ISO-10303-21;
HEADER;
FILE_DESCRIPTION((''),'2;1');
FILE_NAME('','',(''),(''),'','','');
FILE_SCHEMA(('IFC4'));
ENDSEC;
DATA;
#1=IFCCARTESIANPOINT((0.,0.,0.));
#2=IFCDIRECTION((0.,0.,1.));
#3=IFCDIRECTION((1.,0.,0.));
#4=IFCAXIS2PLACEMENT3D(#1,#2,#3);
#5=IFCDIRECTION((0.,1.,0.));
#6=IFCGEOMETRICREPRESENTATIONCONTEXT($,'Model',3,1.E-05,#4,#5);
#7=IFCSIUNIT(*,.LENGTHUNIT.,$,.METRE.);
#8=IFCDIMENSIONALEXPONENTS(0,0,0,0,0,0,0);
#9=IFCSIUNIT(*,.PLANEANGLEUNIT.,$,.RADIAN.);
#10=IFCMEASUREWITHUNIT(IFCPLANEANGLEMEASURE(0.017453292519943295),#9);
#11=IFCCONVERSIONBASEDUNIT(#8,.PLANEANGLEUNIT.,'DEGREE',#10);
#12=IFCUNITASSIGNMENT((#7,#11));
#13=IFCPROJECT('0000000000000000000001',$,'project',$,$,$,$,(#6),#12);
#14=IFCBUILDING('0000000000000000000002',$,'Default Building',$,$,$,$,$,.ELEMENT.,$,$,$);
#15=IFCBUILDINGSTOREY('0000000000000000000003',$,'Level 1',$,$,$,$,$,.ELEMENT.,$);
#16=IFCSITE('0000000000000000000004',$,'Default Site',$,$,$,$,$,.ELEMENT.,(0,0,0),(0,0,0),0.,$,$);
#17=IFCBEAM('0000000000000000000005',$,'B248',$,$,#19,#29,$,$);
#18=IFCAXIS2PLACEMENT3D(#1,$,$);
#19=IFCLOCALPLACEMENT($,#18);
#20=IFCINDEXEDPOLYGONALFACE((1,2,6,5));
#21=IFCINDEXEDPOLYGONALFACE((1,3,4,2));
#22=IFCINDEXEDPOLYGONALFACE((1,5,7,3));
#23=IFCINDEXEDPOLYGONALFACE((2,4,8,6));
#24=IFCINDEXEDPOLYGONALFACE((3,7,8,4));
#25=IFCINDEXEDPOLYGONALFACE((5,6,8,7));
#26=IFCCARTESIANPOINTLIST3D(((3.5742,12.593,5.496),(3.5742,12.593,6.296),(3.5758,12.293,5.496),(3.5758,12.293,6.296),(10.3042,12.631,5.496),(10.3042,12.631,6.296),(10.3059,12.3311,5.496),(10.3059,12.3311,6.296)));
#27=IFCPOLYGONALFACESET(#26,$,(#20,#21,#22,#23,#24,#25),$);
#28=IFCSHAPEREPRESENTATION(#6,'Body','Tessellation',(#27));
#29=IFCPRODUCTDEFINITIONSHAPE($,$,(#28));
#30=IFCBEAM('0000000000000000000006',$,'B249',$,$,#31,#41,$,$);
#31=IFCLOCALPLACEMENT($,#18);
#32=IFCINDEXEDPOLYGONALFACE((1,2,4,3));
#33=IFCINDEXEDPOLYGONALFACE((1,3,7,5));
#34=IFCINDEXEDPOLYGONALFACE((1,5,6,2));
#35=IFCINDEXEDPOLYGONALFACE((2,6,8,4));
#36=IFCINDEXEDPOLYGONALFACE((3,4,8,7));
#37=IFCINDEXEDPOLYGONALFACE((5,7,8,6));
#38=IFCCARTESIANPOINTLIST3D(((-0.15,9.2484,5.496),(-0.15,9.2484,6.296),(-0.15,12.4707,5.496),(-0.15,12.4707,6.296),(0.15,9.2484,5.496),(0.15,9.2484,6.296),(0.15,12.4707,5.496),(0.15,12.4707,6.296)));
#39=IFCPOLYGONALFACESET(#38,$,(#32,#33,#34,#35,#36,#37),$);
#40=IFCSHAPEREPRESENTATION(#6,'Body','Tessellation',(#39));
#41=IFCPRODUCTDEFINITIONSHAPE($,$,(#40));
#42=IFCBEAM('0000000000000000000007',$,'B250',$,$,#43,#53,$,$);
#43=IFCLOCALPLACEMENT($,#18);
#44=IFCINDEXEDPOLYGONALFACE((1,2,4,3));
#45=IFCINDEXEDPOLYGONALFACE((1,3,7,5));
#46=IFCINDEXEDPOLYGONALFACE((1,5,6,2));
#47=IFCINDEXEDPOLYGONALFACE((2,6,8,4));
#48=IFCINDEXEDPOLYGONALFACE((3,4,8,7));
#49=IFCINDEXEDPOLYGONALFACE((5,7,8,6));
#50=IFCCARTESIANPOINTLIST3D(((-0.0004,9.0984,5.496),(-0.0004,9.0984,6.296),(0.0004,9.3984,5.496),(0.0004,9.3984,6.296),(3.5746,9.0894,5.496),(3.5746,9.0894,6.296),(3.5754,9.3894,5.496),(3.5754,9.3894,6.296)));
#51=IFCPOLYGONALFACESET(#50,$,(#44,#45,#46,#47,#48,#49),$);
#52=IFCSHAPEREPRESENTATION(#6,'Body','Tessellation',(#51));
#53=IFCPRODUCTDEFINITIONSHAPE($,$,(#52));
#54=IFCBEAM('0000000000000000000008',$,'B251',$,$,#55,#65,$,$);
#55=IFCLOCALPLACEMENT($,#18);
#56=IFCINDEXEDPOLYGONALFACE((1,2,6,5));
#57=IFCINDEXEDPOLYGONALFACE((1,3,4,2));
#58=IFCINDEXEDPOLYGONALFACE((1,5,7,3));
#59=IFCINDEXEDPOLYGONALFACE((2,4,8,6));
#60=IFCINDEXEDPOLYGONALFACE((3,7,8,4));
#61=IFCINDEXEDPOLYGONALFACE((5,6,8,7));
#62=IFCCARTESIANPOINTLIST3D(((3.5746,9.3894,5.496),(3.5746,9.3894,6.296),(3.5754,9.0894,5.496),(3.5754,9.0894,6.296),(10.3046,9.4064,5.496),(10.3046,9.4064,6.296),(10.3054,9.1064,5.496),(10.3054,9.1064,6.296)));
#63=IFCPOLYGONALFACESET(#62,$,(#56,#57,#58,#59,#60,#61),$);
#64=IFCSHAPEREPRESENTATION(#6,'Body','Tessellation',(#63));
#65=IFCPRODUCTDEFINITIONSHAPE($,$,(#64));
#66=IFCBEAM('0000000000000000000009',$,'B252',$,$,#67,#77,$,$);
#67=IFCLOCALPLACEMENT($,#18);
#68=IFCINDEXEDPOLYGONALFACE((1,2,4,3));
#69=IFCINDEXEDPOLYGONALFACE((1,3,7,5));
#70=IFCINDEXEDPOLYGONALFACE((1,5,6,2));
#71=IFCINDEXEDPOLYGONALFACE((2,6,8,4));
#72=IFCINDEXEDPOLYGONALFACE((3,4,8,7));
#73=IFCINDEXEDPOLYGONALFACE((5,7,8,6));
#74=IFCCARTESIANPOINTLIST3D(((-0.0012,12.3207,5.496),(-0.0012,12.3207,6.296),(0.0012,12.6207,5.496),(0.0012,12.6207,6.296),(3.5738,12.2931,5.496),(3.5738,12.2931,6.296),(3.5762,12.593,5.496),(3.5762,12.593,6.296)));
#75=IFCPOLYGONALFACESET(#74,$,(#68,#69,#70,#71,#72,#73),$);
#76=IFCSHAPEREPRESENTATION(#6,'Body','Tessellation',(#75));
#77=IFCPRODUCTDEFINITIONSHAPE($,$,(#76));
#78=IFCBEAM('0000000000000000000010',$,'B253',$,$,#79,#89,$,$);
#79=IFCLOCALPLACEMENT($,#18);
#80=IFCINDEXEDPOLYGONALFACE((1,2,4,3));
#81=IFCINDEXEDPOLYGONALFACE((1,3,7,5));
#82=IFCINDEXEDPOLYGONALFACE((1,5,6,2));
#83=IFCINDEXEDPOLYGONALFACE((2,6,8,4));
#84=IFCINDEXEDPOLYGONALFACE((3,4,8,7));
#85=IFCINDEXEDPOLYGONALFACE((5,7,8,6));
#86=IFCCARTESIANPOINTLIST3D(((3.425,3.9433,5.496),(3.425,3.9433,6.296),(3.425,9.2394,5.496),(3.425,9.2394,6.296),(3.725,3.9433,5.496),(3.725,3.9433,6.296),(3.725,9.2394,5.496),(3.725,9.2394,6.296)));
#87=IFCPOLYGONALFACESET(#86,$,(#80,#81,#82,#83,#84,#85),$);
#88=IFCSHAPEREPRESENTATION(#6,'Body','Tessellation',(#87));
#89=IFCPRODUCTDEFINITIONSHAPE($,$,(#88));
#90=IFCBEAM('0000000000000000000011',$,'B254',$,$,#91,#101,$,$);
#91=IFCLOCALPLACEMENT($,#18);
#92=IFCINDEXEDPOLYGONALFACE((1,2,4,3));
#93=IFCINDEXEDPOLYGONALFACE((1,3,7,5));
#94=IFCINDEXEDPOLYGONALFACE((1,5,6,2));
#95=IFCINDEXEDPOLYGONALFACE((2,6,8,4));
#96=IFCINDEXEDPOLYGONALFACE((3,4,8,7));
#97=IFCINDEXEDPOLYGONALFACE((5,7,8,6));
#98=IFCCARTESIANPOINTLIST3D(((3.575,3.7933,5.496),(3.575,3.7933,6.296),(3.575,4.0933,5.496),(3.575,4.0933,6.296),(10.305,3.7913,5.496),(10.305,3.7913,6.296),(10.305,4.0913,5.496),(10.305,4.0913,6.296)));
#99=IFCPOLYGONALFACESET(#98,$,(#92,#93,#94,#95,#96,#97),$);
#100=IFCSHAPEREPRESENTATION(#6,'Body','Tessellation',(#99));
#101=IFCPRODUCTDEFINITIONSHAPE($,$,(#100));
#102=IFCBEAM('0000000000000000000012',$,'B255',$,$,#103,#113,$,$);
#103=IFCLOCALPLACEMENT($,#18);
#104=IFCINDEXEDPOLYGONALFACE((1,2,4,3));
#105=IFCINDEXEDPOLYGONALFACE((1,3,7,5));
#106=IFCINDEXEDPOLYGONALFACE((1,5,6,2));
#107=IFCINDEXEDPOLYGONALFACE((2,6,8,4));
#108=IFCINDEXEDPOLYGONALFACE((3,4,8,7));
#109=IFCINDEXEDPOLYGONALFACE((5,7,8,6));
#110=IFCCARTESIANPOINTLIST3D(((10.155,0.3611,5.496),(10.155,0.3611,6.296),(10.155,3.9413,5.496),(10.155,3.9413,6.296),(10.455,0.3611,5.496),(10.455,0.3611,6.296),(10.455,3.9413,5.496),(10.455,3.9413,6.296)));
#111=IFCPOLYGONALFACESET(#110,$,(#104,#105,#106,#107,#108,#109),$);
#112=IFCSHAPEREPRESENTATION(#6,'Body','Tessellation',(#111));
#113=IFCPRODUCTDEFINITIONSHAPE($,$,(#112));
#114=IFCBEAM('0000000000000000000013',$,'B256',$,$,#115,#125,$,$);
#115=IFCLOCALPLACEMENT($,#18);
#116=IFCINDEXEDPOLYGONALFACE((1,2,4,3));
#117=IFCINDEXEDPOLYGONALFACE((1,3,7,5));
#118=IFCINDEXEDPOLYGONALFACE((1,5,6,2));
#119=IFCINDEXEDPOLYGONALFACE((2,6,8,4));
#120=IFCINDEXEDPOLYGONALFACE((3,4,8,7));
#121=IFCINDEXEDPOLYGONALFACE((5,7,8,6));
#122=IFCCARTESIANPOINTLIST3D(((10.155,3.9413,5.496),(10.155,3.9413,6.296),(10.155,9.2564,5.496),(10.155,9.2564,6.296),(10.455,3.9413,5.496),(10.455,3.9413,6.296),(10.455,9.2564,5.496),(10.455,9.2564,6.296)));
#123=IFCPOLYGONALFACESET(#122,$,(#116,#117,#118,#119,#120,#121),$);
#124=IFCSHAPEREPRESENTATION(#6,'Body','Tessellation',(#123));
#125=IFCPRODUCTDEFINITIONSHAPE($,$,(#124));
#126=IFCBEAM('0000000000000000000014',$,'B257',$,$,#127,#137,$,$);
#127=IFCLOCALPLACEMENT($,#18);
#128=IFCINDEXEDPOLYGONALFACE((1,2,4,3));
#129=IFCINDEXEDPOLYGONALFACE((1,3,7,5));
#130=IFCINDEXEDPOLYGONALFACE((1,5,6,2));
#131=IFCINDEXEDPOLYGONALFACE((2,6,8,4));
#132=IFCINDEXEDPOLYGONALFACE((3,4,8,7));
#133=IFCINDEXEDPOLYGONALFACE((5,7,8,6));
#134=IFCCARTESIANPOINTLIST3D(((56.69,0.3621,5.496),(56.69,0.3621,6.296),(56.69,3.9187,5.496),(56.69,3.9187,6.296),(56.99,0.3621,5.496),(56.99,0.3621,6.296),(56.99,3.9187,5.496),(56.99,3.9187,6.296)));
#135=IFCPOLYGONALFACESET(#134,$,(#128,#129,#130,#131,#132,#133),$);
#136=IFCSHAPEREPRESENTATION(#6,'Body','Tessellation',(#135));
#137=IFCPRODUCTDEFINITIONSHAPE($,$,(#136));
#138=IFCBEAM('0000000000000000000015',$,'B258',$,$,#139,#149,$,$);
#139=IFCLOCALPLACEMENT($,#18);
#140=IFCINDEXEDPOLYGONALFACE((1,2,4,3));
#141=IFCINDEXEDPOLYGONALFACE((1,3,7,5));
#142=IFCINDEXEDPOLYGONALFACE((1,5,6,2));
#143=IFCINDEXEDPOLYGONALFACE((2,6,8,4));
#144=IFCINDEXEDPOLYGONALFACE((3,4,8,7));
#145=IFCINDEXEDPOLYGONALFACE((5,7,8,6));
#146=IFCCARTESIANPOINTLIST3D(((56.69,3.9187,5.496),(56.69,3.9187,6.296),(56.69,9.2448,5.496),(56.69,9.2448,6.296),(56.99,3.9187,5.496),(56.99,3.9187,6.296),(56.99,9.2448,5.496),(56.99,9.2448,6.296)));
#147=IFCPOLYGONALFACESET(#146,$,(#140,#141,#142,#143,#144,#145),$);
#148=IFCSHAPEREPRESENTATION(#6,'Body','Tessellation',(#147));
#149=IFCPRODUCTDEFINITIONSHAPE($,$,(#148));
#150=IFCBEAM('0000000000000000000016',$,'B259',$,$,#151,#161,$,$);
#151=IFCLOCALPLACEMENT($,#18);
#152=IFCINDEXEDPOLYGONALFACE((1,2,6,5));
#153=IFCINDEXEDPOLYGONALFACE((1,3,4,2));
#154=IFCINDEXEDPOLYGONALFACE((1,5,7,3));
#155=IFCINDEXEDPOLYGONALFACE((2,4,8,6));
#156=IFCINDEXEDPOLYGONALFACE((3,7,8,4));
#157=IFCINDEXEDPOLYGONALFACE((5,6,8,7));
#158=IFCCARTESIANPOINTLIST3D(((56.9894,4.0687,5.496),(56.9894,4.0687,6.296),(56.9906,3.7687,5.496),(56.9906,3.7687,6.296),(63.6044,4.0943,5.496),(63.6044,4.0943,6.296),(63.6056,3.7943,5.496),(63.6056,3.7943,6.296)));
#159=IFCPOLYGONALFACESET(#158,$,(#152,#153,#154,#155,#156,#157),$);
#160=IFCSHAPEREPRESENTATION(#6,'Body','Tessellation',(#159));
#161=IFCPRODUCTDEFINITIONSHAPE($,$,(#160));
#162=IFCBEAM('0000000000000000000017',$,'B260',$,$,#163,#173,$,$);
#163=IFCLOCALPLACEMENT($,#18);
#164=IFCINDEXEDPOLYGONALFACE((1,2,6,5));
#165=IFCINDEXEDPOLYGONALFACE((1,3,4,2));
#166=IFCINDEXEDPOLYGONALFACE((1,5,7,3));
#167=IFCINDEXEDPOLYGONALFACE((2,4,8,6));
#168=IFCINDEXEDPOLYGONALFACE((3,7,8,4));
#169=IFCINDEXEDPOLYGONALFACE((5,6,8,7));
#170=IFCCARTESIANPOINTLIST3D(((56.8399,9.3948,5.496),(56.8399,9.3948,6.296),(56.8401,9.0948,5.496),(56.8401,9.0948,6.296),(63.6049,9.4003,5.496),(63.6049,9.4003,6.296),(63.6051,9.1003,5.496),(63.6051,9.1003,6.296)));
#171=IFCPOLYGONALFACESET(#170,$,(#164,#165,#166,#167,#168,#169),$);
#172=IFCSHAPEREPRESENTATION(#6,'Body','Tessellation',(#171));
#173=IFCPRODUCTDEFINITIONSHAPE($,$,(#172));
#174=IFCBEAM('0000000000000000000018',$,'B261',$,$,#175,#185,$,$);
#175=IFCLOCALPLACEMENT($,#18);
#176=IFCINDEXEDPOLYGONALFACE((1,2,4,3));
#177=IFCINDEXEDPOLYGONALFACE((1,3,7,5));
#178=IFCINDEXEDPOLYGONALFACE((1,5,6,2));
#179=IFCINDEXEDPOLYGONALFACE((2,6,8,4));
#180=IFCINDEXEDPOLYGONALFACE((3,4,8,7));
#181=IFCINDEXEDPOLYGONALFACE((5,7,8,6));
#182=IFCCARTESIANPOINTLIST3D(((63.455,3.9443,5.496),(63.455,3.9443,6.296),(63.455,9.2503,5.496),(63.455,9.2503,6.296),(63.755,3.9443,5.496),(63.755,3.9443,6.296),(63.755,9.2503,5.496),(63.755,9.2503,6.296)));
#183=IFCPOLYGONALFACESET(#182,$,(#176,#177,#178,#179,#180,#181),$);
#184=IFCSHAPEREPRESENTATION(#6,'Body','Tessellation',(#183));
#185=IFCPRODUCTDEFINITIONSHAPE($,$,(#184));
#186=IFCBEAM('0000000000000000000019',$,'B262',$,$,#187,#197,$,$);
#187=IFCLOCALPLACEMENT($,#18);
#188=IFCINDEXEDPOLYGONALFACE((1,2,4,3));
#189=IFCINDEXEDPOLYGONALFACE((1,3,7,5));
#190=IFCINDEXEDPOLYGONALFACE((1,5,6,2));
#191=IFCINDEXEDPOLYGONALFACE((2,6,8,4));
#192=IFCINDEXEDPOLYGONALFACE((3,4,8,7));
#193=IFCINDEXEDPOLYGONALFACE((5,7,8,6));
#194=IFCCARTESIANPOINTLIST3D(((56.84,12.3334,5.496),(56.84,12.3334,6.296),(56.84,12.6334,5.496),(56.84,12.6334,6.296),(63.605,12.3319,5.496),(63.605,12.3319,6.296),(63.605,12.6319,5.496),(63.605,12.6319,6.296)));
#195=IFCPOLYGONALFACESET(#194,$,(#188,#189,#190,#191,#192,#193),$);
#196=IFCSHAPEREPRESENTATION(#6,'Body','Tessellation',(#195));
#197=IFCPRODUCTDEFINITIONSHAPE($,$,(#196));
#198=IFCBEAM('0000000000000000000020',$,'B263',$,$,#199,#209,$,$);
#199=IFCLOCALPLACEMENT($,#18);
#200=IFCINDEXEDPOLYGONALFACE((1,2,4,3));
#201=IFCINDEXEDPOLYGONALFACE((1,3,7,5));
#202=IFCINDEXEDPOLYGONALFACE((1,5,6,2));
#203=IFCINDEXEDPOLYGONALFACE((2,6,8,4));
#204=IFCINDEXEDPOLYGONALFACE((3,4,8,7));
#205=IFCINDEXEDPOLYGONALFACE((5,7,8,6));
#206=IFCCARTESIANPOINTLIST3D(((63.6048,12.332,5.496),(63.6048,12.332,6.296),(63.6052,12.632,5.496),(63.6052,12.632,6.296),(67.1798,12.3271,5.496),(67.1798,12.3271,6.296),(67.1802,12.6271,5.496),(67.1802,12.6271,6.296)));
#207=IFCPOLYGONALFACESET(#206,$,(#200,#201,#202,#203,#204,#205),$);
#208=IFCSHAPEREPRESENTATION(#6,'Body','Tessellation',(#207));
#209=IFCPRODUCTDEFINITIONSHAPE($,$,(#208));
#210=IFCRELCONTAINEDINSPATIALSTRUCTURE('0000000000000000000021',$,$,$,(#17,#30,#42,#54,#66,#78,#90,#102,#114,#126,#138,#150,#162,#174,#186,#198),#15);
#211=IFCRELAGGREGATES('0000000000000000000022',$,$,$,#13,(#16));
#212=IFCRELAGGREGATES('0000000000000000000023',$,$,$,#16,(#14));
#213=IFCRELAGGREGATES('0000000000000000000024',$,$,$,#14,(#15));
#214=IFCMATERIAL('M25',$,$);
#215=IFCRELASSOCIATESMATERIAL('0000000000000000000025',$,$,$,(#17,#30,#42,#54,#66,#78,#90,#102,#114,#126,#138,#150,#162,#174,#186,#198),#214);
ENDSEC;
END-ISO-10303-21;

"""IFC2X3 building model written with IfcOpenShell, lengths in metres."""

from ifc_helpers import new_model, entity, si_unit, converted_unit, direction, frame, frame_2d, origin_with_axes, place, context, project, spatial, rectangle, extrude, material, element, save


model = new_model("IFC2X3")

# Units and contexts
model_context = context("Model", 3, precision=1e-05, world=origin_with_axes(), true_north=direction((0.0, 1.0, 0.0)))
ifc_project = project(units=[si_unit("LENGTHUNIT", "METRE"), converted_unit("PLANEANGLEUNIT", "DEGREE", entity("IfcPlaneAngleMeasure", 0.017453292519943295), si_unit("PLANEANGLEUNIT", "RADIAN"), dimensions=[0, 0, 0, 0, 0, 0, 0])], contexts=[model_context])

# Site, building, storey
site = spatial("IfcSite", under=ifc_project, Name="Default Site", CompositionType="ELEMENT", RefLatitude=(0, 0, 0), RefLongitude=(0, 0, 0), RefElevation=0.0)
building = spatial("IfcBuilding", under=site, Name="Default Building", CompositionType="ELEMENT")
storey = spatial("IfcBuildingStorey", under=building, Name="Level 1", CompositionType="ELEMENT")

# Beams
ifc_material = material(Name="M25")
placement = place(None, origin_with_axes())
element("IfcBeam", 1, at=placement, inside=storey, material=ifc_material, Name="B248", context=model_context, shape_type="SweptSolid", body=[
    extrude(rectangle(XDim=0.3, YDim=0.8, at=frame_2d((0.0, 0.0), x_axis=(0.0, 1.0, 0.0))), frame((3.575, 12.443, 5.896), z_axis=(0.999984, 0.005654, 0.0), x_axis=(0.0, 0.0, -1.0)), (0.0, 0.0, 1.0), 6.7301),
])
element("IfcBeam", 2, at=placement, inside=storey, material=ifc_material, Name="B249", context=model_context, shape_type="SweptSolid", body=[
    extrude(rectangle(XDim=0.3, YDim=0.8, at=frame_2d((0.0, 0.0), x_axis=(0.0, 1.0, 0.0))), frame((0.0, 9.2484, 5.896), z_axis=(0.0, 1.0, 0.0), x_axis=(0.0, 0.0, -1.0)), (0.0, 0.0, 1.0), 3.2223),
])
element("IfcBeam", 3, at=placement, inside=storey, material=ifc_material, Name="B250", context=model_context, shape_type="SweptSolid", body=[
    extrude(rectangle(XDim=0.3, YDim=0.8, at=frame_2d((0.0, 0.0), x_axis=(0.0, 1.0, 0.0))), frame((0.0, 9.2484, 5.896), z_axis=(0.999997, -0.002499, 0.0), x_axis=(0.0, 0.0, -1.0)), (0.0, 0.0, 1.0), 3.575),
])
element("IfcBeam", 4, at=placement, inside=storey, material=ifc_material, Name="B251", context=model_context, shape_type="SweptSolid", body=[
    extrude(rectangle(XDim=0.3, YDim=0.8, at=frame_2d((0.0, 0.0), x_axis=(0.0, 1.0, 0.0))), frame((3.575, 9.2394, 5.896), z_axis=(0.999997, 0.002522, 0.0), x_axis=(0.0, 0.0, -1.0)), (0.0, 0.0, 1.0), 6.73),
])
element("IfcBeam", 5, at=placement, inside=storey, material=ifc_material, Name="B252", context=model_context, shape_type="SweptSolid", body=[
    extrude(rectangle(XDim=0.3, YDim=0.8, at=frame_2d((0.0, 0.0), x_axis=(0.0, 1.0, 0.0))), frame((0.0, 12.4707, 5.896), z_axis=(0.99997, -0.007734, 0.0), x_axis=(0.0, 0.0, -1.0)), (0.0, 0.0, 1.0), 3.5751),
])
element("IfcBeam", 6, at=placement, inside=storey, material=ifc_material, Name="B253", context=model_context, shape_type="SweptSolid", body=[
    extrude(rectangle(XDim=0.3, YDim=0.8, at=frame_2d((0.0, 0.0), x_axis=(0.0, 1.0, 0.0))), frame((3.575, 3.9433, 5.896), z_axis=(0.0, 1.0, 0.0), x_axis=(0.0, 0.0, -1.0)), (0.0, 0.0, 1.0), 5.2961),
])
element("IfcBeam", 7, at=placement, inside=storey, material=ifc_material, Name="B254", context=model_context, shape_type="SweptSolid", body=[
    extrude(rectangle(XDim=0.3, YDim=0.8, at=frame_2d((0.0, 0.0), x_axis=(0.0, 1.0, 0.0))), frame((3.575, 3.9433, 5.896), z_axis=(1.0, -0.000302, 0.0), x_axis=(0.0, 0.0, -1.0)), (0.0, 0.0, 1.0), 6.73),
])
element("IfcBeam", 8, at=placement, inside=storey, material=ifc_material, Name="B255", context=model_context, shape_type="SweptSolid", body=[
    extrude(rectangle(XDim=0.3, YDim=0.8, at=frame_2d((0.0, 0.0), x_axis=(0.0, 1.0, 0.0))), frame((10.305, 3.9413, 5.896), z_axis=(0.0, -1.0, 0.0), x_axis=(0.0, 0.0, -1.0)), (0.0, 0.0, 1.0), 3.5802),
])
element("IfcBeam", 9, at=placement, inside=storey, material=ifc_material, Name="B256", context=model_context, shape_type="SweptSolid", body=[
    extrude(rectangle(XDim=0.3, YDim=0.8, at=frame_2d((0.0, 0.0), x_axis=(0.0, 1.0, 0.0))), frame((10.305, 3.9413, 5.896), z_axis=(0.0, 1.0, 0.0), x_axis=(0.0, 0.0, -1.0)), (0.0, 0.0, 1.0), 5.3151),
])
element("IfcBeam", 10, at=placement, inside=storey, material=ifc_material, Name="B257", context=model_context, shape_type="SweptSolid", body=[
    extrude(rectangle(XDim=0.3, YDim=0.8, at=frame_2d((0.0, 0.0), x_axis=(0.0, 1.0, 0.0))), frame((56.84, 0.3621, 5.896), z_axis=(0.0, 1.0, 0.0), x_axis=(0.0, 0.0, -1.0)), (0.0, 0.0, 1.0), 3.5566),
])
element("IfcBeam", 11, at=placement, inside=storey, material=ifc_material, Name="B258", context=model_context, shape_type="SweptSolid", body=[
    extrude(rectangle(XDim=0.3, YDim=0.8, at=frame_2d((0.0, 0.0), x_axis=(0.0, 1.0, 0.0))), frame((56.84, 3.9187, 5.896), z_axis=(0.0, 1.0, 0.0), x_axis=(0.0, 0.0, -1.0)), (0.0, 0.0, 1.0), 5.3261),
])
element("IfcBeam", 12, at=placement, inside=storey, material=ifc_material, Name="B259", context=model_context, shape_type="SweptSolid", body=[
    extrude(rectangle(XDim=0.3, YDim=0.8, at=frame_2d((0.0, 0.0), x_axis=(0.0, 1.0, 0.0))), frame((56.99, 3.9187, 5.896), z_axis=(0.999993, 0.003873, 0.0), x_axis=(0.0, 0.0, -1.0)), (0.0, 0.0, 1.0), 6.6151),
])
element("IfcBeam", 13, at=placement, inside=storey, material=ifc_material, Name="B260", context=model_context, shape_type="SweptSolid", body=[
    extrude(rectangle(XDim=0.3, YDim=0.8, at=frame_2d((0.0, 0.0), x_axis=(0.0, 1.0, 0.0))), frame((56.84, 9.2448, 5.896), z_axis=(1.0, 0.000816, 0.0), x_axis=(0.0, 0.0, -1.0)), (0.0, 0.0, 1.0), 6.765),
])
element("IfcBeam", 14, at=placement, inside=storey, material=ifc_material, Name="B261", context=model_context, shape_type="SweptSolid", body=[
    extrude(rectangle(XDim=0.3, YDim=0.8, at=frame_2d((0.0, 0.0), x_axis=(0.0, 1.0, 0.0))), frame((63.605, 3.9443, 5.896), z_axis=(0.0, 1.0, 0.0), x_axis=(0.0, 0.0, -1.0)), (0.0, 0.0, 1.0), 5.306),
])
element("IfcBeam", 15, at=placement, inside=storey, material=ifc_material, Name="B262", context=model_context, shape_type="SweptSolid", body=[
    extrude(rectangle(XDim=0.3, YDim=0.8, at=frame_2d((0.0, 0.0), x_axis=(0.0, 1.0, 0.0))), frame((56.84, 12.4834, 5.896), z_axis=(1.0, -0.000216, 0.0), x_axis=(0.0, 0.0, -1.0)), (0.0, 0.0, 1.0), 6.765),
])
element("IfcBeam", 16, at=placement, inside=storey, material=ifc_material, Name="B263", context=model_context, shape_type="SweptSolid", body=[
    extrude(rectangle(XDim=0.3, YDim=0.8, at=frame_2d((0.0, 0.0), x_axis=(0.0, 1.0, 0.0))), frame((63.605, 12.482, 5.896), z_axis=(0.999999, -0.001379, 0.0), x_axis=(0.0, 0.0, -1.0)), (0.0, 0.0, 1.0), 3.575),
])

save(model, "model.ifc")
